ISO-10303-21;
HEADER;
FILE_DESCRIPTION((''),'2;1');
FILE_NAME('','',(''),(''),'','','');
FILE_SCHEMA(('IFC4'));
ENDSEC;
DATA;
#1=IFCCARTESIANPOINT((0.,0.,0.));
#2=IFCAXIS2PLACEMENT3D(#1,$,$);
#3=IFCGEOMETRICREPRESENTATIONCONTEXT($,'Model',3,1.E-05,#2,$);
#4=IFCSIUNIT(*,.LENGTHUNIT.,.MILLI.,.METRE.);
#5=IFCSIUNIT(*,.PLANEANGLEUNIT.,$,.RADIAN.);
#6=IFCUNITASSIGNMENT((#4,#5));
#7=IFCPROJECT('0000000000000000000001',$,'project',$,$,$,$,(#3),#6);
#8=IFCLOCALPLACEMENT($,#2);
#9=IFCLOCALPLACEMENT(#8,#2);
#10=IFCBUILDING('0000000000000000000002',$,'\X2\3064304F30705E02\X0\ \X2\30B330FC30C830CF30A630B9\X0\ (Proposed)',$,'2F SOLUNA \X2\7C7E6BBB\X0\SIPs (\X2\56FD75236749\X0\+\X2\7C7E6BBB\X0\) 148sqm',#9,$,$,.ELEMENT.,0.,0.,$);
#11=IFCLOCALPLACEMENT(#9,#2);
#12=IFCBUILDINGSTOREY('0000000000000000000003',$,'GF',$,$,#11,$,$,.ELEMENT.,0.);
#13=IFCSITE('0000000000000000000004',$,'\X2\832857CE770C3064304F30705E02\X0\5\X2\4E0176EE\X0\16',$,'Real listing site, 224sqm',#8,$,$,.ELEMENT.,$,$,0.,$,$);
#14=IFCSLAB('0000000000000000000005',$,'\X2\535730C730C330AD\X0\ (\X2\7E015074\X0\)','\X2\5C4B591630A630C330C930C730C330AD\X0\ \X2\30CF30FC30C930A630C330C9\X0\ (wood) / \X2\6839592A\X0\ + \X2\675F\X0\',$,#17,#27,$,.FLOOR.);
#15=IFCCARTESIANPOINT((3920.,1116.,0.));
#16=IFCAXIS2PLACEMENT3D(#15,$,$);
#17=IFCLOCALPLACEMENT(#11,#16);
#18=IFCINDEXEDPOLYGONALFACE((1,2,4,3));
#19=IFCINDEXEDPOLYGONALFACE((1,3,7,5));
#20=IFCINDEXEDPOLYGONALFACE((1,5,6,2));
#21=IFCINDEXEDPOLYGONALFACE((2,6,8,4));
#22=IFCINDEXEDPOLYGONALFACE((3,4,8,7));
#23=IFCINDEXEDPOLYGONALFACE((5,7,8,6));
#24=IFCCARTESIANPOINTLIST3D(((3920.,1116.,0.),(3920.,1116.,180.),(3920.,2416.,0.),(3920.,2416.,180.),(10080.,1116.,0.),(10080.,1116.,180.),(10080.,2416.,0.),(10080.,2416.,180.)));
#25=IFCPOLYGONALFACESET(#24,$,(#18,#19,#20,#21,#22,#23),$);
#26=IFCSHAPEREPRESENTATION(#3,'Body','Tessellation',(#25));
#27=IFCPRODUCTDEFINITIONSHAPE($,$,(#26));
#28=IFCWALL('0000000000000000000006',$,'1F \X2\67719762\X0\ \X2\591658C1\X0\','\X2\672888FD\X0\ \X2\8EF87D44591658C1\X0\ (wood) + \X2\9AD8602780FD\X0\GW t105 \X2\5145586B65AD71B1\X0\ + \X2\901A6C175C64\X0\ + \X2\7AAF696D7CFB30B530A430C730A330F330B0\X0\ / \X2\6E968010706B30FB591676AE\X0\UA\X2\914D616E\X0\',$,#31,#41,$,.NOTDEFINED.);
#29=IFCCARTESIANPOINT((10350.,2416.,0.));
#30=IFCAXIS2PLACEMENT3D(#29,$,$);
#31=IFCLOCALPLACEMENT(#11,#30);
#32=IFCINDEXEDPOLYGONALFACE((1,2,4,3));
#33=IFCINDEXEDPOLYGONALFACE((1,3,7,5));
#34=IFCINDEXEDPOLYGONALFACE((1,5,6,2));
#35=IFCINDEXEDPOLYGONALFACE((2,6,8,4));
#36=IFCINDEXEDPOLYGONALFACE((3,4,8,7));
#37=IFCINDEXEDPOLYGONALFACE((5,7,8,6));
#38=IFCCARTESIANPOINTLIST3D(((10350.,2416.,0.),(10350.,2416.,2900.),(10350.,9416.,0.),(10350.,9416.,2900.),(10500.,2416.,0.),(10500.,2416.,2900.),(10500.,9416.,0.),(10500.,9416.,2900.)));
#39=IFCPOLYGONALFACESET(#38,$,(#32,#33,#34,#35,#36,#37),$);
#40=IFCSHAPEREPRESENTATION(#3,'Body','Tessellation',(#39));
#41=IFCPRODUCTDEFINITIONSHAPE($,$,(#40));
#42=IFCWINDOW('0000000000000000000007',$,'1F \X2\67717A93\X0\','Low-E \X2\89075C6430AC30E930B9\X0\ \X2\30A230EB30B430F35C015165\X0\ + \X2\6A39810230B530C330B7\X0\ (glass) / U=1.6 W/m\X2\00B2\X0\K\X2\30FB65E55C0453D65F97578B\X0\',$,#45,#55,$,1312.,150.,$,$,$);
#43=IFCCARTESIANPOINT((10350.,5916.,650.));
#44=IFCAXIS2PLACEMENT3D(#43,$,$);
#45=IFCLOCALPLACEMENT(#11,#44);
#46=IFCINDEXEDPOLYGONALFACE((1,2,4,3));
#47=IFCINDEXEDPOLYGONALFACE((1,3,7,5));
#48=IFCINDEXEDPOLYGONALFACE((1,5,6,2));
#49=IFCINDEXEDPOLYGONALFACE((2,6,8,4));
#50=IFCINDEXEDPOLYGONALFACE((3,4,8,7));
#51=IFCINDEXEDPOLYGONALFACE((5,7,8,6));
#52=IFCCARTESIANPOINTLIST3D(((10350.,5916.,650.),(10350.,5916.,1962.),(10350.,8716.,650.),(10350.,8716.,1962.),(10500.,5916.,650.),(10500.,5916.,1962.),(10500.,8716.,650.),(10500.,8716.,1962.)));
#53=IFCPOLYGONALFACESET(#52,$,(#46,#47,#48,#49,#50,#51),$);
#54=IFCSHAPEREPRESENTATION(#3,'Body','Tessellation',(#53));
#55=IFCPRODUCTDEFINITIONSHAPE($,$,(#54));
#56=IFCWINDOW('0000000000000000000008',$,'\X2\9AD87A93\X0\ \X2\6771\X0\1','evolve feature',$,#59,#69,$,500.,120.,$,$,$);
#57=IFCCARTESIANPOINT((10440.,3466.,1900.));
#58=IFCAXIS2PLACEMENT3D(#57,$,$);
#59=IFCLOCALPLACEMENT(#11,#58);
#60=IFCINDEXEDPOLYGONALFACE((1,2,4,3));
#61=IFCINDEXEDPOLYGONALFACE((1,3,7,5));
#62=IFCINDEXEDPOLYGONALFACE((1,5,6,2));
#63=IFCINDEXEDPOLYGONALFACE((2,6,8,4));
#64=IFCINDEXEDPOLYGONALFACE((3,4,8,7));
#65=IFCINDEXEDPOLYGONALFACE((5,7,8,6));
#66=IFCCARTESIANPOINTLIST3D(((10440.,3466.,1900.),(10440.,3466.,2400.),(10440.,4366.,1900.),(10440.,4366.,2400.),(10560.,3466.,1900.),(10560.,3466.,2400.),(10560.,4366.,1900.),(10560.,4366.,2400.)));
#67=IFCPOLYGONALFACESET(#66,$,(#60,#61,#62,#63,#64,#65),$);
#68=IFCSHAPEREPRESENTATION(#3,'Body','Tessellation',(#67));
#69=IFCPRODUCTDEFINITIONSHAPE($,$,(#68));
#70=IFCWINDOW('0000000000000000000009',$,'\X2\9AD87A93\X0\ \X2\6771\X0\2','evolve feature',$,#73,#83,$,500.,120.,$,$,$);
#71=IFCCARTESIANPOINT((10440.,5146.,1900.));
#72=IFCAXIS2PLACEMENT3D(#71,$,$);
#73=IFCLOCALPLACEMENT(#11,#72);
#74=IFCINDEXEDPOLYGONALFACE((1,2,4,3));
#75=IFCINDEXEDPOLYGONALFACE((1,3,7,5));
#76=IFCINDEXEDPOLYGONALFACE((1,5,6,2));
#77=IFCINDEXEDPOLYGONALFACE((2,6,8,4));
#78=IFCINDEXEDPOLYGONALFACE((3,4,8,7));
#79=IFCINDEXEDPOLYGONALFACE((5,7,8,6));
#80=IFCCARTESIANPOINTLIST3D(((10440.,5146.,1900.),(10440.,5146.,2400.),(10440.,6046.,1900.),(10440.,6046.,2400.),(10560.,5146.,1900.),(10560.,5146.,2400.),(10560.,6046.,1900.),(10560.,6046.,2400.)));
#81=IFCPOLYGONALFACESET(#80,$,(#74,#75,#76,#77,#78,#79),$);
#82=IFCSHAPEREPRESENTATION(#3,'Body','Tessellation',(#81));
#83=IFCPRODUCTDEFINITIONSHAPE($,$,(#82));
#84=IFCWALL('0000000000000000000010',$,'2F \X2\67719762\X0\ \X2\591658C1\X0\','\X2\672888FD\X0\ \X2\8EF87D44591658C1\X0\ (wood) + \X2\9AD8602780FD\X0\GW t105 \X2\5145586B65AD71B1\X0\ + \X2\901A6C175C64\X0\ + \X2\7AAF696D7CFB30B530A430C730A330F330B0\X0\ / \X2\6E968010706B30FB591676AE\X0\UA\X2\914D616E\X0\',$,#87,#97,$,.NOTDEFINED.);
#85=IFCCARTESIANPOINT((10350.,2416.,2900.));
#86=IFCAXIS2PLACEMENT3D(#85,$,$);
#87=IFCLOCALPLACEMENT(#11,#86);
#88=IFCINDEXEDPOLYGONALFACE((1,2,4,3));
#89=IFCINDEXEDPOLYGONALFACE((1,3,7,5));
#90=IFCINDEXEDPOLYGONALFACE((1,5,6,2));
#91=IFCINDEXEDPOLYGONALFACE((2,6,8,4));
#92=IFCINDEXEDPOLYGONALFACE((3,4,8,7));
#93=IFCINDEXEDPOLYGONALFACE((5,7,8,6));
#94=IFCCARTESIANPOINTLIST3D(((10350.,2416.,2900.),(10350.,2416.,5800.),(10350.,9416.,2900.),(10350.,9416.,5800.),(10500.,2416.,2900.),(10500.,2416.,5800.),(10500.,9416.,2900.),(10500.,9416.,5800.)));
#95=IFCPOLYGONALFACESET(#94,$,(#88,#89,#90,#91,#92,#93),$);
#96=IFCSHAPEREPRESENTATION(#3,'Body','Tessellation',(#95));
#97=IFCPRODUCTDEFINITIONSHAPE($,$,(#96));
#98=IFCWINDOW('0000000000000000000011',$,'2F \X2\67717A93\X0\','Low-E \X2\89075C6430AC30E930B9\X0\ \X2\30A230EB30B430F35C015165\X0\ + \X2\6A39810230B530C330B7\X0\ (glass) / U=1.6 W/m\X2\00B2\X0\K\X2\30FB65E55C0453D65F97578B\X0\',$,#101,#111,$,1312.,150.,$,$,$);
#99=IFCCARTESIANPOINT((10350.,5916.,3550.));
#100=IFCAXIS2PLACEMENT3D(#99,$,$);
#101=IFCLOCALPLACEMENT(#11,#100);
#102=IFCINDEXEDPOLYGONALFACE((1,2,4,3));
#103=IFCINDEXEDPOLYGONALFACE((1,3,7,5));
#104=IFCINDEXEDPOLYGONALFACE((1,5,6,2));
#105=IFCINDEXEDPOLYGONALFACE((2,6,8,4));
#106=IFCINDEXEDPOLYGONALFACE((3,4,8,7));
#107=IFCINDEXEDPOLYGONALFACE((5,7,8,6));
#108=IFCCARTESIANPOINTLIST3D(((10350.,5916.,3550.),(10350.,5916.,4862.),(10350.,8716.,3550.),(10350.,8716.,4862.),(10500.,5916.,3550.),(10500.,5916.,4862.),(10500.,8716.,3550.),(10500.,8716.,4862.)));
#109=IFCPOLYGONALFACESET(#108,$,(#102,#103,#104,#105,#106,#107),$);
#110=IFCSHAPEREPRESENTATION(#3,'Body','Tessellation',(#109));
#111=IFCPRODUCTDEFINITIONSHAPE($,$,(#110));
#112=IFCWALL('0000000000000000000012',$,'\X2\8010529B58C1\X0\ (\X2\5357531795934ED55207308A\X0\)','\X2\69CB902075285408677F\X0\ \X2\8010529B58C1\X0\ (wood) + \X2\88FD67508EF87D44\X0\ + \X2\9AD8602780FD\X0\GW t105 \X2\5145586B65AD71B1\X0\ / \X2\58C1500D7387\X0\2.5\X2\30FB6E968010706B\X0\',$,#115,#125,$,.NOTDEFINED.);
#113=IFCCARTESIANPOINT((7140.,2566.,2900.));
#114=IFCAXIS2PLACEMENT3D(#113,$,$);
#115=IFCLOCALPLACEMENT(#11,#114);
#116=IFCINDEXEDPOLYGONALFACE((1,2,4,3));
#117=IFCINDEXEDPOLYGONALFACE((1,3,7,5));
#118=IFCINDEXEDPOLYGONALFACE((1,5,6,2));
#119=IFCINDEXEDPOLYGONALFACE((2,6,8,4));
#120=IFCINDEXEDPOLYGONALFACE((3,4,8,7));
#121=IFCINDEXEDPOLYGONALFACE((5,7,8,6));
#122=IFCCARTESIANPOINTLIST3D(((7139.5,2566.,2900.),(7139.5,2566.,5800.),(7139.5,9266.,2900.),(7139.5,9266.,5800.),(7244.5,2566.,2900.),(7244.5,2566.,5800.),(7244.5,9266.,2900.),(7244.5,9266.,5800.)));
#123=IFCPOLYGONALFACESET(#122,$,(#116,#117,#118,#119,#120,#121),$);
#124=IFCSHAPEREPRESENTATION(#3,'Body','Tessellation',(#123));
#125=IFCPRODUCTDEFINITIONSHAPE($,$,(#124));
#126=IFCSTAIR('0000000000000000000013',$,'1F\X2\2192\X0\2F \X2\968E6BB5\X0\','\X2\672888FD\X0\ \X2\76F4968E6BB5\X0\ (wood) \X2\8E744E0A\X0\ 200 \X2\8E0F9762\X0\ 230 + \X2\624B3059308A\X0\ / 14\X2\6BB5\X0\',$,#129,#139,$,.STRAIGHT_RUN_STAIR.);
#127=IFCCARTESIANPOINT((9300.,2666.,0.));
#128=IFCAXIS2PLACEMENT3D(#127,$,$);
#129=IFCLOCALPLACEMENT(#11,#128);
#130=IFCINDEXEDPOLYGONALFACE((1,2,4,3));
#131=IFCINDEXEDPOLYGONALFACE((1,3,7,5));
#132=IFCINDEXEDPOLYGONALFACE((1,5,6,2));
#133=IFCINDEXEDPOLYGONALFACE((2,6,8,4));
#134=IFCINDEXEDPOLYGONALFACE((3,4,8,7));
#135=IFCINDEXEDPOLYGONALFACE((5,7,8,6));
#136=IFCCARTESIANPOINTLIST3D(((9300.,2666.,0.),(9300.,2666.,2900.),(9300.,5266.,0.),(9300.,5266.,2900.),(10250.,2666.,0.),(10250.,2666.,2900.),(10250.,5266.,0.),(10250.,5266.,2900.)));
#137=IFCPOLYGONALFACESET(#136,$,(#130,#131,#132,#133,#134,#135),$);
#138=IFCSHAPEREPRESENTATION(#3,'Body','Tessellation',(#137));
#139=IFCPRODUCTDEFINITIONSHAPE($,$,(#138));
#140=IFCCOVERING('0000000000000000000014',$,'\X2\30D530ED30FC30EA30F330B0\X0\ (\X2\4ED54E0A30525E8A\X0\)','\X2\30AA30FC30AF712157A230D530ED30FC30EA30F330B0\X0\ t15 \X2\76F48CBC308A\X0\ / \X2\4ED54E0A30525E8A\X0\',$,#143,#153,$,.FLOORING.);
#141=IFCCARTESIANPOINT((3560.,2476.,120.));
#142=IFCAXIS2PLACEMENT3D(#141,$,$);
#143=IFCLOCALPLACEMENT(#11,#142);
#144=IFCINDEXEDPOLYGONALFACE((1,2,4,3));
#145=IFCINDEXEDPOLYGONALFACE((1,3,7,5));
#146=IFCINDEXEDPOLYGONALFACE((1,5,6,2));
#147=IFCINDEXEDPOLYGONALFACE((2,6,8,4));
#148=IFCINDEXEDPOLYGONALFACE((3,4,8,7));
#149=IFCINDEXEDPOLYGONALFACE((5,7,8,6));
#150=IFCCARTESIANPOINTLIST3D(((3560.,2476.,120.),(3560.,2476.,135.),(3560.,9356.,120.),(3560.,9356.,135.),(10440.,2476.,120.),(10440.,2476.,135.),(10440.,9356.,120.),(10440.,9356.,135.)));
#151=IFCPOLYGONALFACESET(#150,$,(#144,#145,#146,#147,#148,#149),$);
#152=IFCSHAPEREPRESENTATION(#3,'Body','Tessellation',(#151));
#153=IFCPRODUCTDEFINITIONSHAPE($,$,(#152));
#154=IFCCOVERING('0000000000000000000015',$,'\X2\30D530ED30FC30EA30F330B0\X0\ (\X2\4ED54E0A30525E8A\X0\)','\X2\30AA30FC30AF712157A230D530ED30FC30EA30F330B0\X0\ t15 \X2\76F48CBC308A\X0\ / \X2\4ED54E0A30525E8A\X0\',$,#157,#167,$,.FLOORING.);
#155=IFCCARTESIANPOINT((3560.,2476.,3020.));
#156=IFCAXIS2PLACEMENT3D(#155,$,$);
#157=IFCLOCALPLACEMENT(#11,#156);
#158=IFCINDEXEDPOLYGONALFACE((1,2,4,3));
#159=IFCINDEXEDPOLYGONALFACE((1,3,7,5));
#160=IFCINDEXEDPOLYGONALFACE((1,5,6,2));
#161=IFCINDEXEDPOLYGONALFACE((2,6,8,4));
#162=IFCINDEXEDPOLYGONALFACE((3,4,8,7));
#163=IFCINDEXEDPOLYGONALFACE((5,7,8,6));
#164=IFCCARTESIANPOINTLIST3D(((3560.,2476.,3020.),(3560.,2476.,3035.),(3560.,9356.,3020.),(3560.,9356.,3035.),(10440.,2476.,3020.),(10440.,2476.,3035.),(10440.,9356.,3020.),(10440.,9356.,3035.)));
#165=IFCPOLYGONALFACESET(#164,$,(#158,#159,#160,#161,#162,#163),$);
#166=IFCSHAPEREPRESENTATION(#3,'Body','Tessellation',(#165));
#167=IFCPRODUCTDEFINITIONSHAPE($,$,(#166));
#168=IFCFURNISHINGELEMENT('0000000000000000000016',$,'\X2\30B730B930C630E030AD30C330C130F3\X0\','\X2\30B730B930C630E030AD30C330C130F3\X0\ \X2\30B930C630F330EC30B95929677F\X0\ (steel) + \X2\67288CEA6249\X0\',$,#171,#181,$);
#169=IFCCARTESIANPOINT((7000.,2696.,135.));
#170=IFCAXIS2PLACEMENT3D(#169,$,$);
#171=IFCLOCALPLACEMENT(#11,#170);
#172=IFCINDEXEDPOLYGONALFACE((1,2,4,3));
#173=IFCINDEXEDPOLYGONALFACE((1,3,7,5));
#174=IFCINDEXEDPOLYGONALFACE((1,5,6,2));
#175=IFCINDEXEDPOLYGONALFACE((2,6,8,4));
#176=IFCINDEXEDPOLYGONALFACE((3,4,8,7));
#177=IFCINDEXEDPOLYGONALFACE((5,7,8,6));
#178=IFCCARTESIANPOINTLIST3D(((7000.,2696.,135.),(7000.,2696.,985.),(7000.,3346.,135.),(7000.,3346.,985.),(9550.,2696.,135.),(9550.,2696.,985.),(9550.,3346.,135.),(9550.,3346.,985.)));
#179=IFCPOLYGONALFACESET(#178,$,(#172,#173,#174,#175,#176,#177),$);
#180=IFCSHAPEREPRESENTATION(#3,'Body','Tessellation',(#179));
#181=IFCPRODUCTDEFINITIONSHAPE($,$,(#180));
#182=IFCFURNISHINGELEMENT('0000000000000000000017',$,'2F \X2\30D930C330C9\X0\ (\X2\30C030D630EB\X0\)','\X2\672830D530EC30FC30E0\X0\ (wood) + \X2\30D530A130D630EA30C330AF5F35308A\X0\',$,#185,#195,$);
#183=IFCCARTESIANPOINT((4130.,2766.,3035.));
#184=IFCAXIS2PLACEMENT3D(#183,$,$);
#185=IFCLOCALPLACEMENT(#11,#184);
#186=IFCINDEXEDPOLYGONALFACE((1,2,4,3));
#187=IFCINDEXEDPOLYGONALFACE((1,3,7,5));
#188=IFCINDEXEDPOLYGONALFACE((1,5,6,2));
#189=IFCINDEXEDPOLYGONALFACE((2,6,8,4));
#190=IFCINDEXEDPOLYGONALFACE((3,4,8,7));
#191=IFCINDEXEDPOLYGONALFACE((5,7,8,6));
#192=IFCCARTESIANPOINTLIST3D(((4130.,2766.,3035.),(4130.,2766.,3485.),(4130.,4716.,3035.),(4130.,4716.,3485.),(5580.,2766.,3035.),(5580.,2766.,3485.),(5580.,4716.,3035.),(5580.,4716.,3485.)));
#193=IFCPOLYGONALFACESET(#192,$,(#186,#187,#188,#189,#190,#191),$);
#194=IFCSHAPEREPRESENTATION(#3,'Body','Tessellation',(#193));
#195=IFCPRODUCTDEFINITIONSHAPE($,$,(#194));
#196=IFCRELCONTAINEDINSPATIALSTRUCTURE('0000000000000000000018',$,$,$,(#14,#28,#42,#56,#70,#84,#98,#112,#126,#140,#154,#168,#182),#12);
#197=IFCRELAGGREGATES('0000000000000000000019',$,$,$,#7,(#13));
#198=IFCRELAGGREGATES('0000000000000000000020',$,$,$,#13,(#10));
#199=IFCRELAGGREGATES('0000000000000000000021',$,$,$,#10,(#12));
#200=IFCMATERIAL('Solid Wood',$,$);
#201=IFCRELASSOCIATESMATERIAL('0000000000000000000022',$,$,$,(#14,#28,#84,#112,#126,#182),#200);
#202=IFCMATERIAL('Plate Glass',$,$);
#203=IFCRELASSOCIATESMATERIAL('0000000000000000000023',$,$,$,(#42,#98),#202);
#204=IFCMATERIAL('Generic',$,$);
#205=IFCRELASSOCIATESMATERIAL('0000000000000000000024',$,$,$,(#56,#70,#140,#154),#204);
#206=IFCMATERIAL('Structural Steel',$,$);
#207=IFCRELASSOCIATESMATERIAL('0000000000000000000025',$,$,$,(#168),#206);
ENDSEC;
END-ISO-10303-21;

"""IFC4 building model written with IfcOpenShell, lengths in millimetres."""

from ifc_helpers import new_model, si_unit, frame, frame_2d, origin, place, context, project, spatial, rectangle, extrude, material, element, fill, save


model = new_model("IFC4")

# Units and contexts
model_context = context("Model", 3, precision=1e-05, world=origin())
ifc_project = project(units=[si_unit("LENGTHUNIT", "METRE", prefix="MILLI"), si_unit("PLANEANGLEUNIT", "RADIAN")], contexts=[model_context])

# Site, building, storey
site_placement = place(None, origin())
site = spatial("IfcSite", under=ifc_project, at=site_placement, Name="茨城県つくば市5丁目16", ObjectType="Real listing site, 224sqm", CompositionType="ELEMENT", RefElevation=0.0)
building_placement = place(site_placement, origin())
building = spatial("IfcBuilding", under=site, at=building_placement, Name="つくば市 コートハウス (Proposed)", ObjectType="2F SOLUNA 籾殻SIPs (国産杉+籾殻) 148sqm", CompositionType="ELEMENT", ElevationOfRefHeight=0.0, ElevationOfTerrain=0.0)
storey_placement = place(building_placement, origin())
storey = spatial("IfcBuildingStorey", under=building, at=storey_placement, Name="GF", CompositionType="ELEMENT", Elevation=0.0)

# Slab
ifc_material_1 = material(Name="Solid Wood")
slab_placement = place(storey_placement, frame((3920.0, 1116.0, 0.0)))
element("IfcSlab", 1, at=slab_placement, inside=storey, material=ifc_material_1, Name="南デッキ (縁側)", Description="屋外ウッドデッキ ハードウッド (wood) / 根太 + 束", PredefinedType="FLOOR", context=model_context, shape_type="SweptSolid", body=[
    extrude(rectangle(XDim=6160.0, YDim=1300.0, at=frame_2d((3080.0, 650.0))), frame((3920.0, 1116.0, 0.0)), (0.0, 0.0, 1.0), 180.0),
])

# Wall, openings, windows
wall_1_placement = place(storey_placement, frame((10350.0, 2416.0, 0.0)))
wall_1 = element("IfcWall", 2, at=wall_1_placement, inside=storey, material=ifc_material_1, Name="1F 東面 外壁", Description="木製 軸組外壁 (wood) + 高性能GW t105 充填断熱 + 通気層 + 窯業系サイディング / 準耐火・外皮UA配慮", PredefinedType="NOTDEFINED", context=model_context, shape_type="SweptSolid", body=[
    extrude(rectangle(XDim=150.0, YDim=7000.0, at=frame_2d((75.0, 3500.0))), frame((10350.0, 2416.0, 0.0)), (0.0, 0.0, 1.0), 2900.0),
])
opening_1_placement = place(storey_placement, frame((10350.0, 5916.0, 650.0)))
opening_1 = element("IfcOpeningElement", 3, at=opening_1_placement, cuts=wall_1, PredefinedType="NOTDEFINED", context=model_context, shape_type="SweptSolid", body=[
    extrude(rectangle(XDim=150.0, YDim=2800.0, at=frame_2d((75.0, 1400.0))), frame((10350.0, 5916.0, 650.0)), (0.0, 0.0, 1.0), 1312.0),
])
opening_2_placement = place(storey_placement, frame((10440.0, 3466.0, 1900.0)))
opening_2 = element("IfcOpeningElement", 4, at=opening_2_placement, cuts=wall_1, PredefinedType="NOTDEFINED", context=model_context, shape_type="SweptSolid", body=[
    extrude(rectangle(XDim=120.0, YDim=900.0, at=frame_2d((60.0, 450.0))), frame((10440.0, 3466.0, 1900.0)), (0.0, 0.0, 1.0), 500.0),
])
opening_3_placement = place(storey_placement, frame((10440.0, 5146.0, 1900.0)))
opening_3 = element("IfcOpeningElement", 5, at=opening_3_placement, cuts=wall_1, PredefinedType="NOTDEFINED", context=model_context, shape_type="SweptSolid", body=[
    extrude(rectangle(XDim=120.0, YDim=900.0, at=frame_2d((60.0, 450.0))), frame((10440.0, 5146.0, 1900.0)), (0.0, 0.0, 1.0), 500.0),
])
ifc_material_2 = material(Name="Plate Glass")
window_1_placement = place(storey_placement, frame((10350.0, 5916.0, 650.0)))
window_1 = element("IfcWindow", 6, at=window_1_placement, inside=storey, material=ifc_material_2, Name="1F 東窓", Description="Low-E 複層ガラス アルゴン封入 + 樹脂サッシ (glass) / U=1.6 W/m²K・日射取得型", OverallHeight=1312.0, OverallWidth=150.0, context=model_context, shape_type="SweptSolid", body=[
    extrude(rectangle(XDim=150.0, YDim=2800.0, at=frame_2d((75.0, 1400.0))), frame((10350.0, 5916.0, 650.0)), (0.0, 0.0, 1.0), 1312.0),
])
fill(opening_1, window_1)
ifc_material_3 = material(Name="Generic")
window_2_placement = place(storey_placement, frame((10440.0, 3466.0, 1900.0)))
window_2 = element("IfcWindow", 7, at=window_2_placement, inside=storey, material=ifc_material_3, Name="高窓 東1", Description="evolve feature", OverallHeight=500.0, OverallWidth=120.0, context=model_context, shape_type="SweptSolid", body=[
    extrude(rectangle(XDim=120.0, YDim=900.0, at=frame_2d((60.0, 450.0))), frame((10440.0, 3466.0, 1900.0)), (0.0, 0.0, 1.0), 500.0),
])
fill(opening_2, window_2)
window_3_placement = place(storey_placement, frame((10440.0, 5146.0, 1900.0)))
window_3 = element("IfcWindow", 8, at=window_3_placement, inside=storey, material=ifc_material_3, Name="高窓 東2", Description="evolve feature", OverallHeight=500.0, OverallWidth=120.0, context=model_context, shape_type="SweptSolid", body=[
    extrude(rectangle(XDim=120.0, YDim=900.0, at=frame_2d((60.0, 450.0))), frame((10440.0, 5146.0, 1900.0)), (0.0, 0.0, 1.0), 500.0),
])
fill(opening_3, window_3)

# Wall, opening, window
wall_2_placement = place(storey_placement, frame((10350.0, 2416.0, 2900.0)))
wall_2 = element("IfcWall", 9, at=wall_2_placement, inside=storey, material=ifc_material_1, Name="2F 東面 外壁", Description="木製 軸組外壁 (wood) + 高性能GW t105 充填断熱 + 通気層 + 窯業系サイディング / 準耐火・外皮UA配慮", PredefinedType="NOTDEFINED", context=model_context, shape_type="SweptSolid", body=[
    extrude(rectangle(XDim=150.0, YDim=7000.0, at=frame_2d((75.0, 3500.0))), frame((10350.0, 2416.0, 2900.0)), (0.0, 0.0, 1.0), 2900.0),
])
opening_4_placement = place(storey_placement, frame((10350.0, 5916.0, 3550.0)))
opening_4 = element("IfcOpeningElement", 10, at=opening_4_placement, cuts=wall_2, PredefinedType="NOTDEFINED", context=model_context, shape_type="SweptSolid", body=[
    extrude(rectangle(XDim=150.0, YDim=2800.0, at=frame_2d((75.0, 1400.0))), frame((10350.0, 5916.0, 3550.0)), (0.0, 0.0, 1.0), 1312.0),
])
window_4_placement = place(storey_placement, frame((10350.0, 5916.0, 3550.0)))
window_4 = element("IfcWindow", 11, at=window_4_placement, inside=storey, material=ifc_material_2, Name="2F 東窓", Description="Low-E 複層ガラス アルゴン封入 + 樹脂サッシ (glass) / U=1.6 W/m²K・日射取得型", OverallHeight=1312.0, OverallWidth=150.0, context=model_context, shape_type="SweptSolid", body=[
    extrude(rectangle(XDim=150.0, YDim=2800.0, at=frame_2d((75.0, 1400.0))), frame((10350.0, 5916.0, 3550.0)), (0.0, 0.0, 1.0), 1312.0),
])
fill(opening_4, window_4)

# Wall
wall_3_placement = place(storey_placement, frame((7140.0, 2566.0, 2900.0)))
element("IfcWall", 12, at=wall_3_placement, inside=storey, material=ifc_material_1, Name="耐力壁 (南北間仕切り)", Description="構造用合板 耐力壁 (wood) + 製材軸組 + 高性能GW t105 充填断熱 / 壁倍率2.5・準耐火", PredefinedType="NOTDEFINED", context=model_context, shape_type="SweptSolid", body=[
    extrude(rectangle(XDim=105.0, YDim=6700.0, at=frame_2d((52.0, 3350.0))), frame((7140.0, 2566.0, 2900.0)), (0.0, 0.0, 1.0), 2900.0),
])

# Stair
stair_placement = place(storey_placement, frame((9300.0, 2666.0, 0.0)))
element("IfcStair", 13, at=stair_placement, inside=storey, material=ifc_material_1, Name="1F→2F 階段", Description="木製 直階段 (wood) 蹴上 200 踏面 230 + 手すり / 14段", PredefinedType="STRAIGHT_RUN_STAIR", context=model_context, shape_type="SweptSolid", body=[
    extrude(rectangle(XDim=950.0, YDim=2600.0, at=frame_2d((475.0, 1300.0))), frame((9300.0, 2666.0, 0.0)), (0.0, 0.0, 1.0), 2900.0),
])

# Coverings
covering_1_placement = place(storey_placement, frame((3560.0, 2476.0, 120.0)))
element("IfcCovering", 14, at=covering_1_placement, inside=storey, material=ifc_material_3, Name="フローリング (仕上げ床)", Description="オーク無垢フローリング t15 直貼り / 仕上げ床", PredefinedType="FLOORING", context=model_context, shape_type="SweptSolid", body=[
    extrude(rectangle(XDim=6880.0, YDim=6880.0, at=frame_2d((3440.0, 3440.0))), frame((3560.0, 2476.0, 120.0)), (0.0, 0.0, 1.0), 15.0),
])
covering_2_placement = place(storey_placement, frame((3560.0, 2476.0, 3020.0)))
element("IfcCovering", 15, at=covering_2_placement, inside=storey, material=ifc_material_3, Name="フローリング (仕上げ床)", Description="オーク無垢フローリング t15 直貼り / 仕上げ床", PredefinedType="FLOORING", context=model_context, shape_type="SweptSolid", body=[
    extrude(rectangle(XDim=6880.0, YDim=6880.0, at=frame_2d((3440.0, 3440.0))), frame((3560.0, 2476.0, 3020.0)), (0.0, 0.0, 1.0), 15.0),
])

# Furnishing elements
ifc_material_4 = material(Name="Structural Steel")
furnishing_1_placement = place(storey_placement, frame((7000.0, 2696.0, 135.0)))
element("IfcFurnishingElement", 16, at=furnishing_1_placement, inside=storey, material=ifc_material_4, Name="システムキッチン", Description="システムキッチン ステンレス天板 (steel) + 木質扉", context=model_context, shape_type="SweptSolid", body=[
    extrude(rectangle(XDim=2550.0, YDim=650.0, at=frame_2d((1275.0, 325.0))), frame((7000.0, 2696.0, 135.0)), (0.0, 0.0, 1.0), 850.0),
])
furnishing_2_placement = place(storey_placement, frame((4130.0, 2766.0, 3035.0)))
element("IfcFurnishingElement", 17, at=furnishing_2_placement, inside=storey, material=ifc_material_1, Name="2F ベッド (ダブル)", Description="木フレーム (wood) + ファブリック張り", context=model_context, shape_type="SweptSolid", body=[
    extrude(rectangle(XDim=1450.0, YDim=1950.0, at=frame_2d((725.0, 975.0))), frame((4130.0, 2766.0, 3035.0)), (0.0, 0.0, 1.0), 450.0),
])

save(model, "model.ifc")
